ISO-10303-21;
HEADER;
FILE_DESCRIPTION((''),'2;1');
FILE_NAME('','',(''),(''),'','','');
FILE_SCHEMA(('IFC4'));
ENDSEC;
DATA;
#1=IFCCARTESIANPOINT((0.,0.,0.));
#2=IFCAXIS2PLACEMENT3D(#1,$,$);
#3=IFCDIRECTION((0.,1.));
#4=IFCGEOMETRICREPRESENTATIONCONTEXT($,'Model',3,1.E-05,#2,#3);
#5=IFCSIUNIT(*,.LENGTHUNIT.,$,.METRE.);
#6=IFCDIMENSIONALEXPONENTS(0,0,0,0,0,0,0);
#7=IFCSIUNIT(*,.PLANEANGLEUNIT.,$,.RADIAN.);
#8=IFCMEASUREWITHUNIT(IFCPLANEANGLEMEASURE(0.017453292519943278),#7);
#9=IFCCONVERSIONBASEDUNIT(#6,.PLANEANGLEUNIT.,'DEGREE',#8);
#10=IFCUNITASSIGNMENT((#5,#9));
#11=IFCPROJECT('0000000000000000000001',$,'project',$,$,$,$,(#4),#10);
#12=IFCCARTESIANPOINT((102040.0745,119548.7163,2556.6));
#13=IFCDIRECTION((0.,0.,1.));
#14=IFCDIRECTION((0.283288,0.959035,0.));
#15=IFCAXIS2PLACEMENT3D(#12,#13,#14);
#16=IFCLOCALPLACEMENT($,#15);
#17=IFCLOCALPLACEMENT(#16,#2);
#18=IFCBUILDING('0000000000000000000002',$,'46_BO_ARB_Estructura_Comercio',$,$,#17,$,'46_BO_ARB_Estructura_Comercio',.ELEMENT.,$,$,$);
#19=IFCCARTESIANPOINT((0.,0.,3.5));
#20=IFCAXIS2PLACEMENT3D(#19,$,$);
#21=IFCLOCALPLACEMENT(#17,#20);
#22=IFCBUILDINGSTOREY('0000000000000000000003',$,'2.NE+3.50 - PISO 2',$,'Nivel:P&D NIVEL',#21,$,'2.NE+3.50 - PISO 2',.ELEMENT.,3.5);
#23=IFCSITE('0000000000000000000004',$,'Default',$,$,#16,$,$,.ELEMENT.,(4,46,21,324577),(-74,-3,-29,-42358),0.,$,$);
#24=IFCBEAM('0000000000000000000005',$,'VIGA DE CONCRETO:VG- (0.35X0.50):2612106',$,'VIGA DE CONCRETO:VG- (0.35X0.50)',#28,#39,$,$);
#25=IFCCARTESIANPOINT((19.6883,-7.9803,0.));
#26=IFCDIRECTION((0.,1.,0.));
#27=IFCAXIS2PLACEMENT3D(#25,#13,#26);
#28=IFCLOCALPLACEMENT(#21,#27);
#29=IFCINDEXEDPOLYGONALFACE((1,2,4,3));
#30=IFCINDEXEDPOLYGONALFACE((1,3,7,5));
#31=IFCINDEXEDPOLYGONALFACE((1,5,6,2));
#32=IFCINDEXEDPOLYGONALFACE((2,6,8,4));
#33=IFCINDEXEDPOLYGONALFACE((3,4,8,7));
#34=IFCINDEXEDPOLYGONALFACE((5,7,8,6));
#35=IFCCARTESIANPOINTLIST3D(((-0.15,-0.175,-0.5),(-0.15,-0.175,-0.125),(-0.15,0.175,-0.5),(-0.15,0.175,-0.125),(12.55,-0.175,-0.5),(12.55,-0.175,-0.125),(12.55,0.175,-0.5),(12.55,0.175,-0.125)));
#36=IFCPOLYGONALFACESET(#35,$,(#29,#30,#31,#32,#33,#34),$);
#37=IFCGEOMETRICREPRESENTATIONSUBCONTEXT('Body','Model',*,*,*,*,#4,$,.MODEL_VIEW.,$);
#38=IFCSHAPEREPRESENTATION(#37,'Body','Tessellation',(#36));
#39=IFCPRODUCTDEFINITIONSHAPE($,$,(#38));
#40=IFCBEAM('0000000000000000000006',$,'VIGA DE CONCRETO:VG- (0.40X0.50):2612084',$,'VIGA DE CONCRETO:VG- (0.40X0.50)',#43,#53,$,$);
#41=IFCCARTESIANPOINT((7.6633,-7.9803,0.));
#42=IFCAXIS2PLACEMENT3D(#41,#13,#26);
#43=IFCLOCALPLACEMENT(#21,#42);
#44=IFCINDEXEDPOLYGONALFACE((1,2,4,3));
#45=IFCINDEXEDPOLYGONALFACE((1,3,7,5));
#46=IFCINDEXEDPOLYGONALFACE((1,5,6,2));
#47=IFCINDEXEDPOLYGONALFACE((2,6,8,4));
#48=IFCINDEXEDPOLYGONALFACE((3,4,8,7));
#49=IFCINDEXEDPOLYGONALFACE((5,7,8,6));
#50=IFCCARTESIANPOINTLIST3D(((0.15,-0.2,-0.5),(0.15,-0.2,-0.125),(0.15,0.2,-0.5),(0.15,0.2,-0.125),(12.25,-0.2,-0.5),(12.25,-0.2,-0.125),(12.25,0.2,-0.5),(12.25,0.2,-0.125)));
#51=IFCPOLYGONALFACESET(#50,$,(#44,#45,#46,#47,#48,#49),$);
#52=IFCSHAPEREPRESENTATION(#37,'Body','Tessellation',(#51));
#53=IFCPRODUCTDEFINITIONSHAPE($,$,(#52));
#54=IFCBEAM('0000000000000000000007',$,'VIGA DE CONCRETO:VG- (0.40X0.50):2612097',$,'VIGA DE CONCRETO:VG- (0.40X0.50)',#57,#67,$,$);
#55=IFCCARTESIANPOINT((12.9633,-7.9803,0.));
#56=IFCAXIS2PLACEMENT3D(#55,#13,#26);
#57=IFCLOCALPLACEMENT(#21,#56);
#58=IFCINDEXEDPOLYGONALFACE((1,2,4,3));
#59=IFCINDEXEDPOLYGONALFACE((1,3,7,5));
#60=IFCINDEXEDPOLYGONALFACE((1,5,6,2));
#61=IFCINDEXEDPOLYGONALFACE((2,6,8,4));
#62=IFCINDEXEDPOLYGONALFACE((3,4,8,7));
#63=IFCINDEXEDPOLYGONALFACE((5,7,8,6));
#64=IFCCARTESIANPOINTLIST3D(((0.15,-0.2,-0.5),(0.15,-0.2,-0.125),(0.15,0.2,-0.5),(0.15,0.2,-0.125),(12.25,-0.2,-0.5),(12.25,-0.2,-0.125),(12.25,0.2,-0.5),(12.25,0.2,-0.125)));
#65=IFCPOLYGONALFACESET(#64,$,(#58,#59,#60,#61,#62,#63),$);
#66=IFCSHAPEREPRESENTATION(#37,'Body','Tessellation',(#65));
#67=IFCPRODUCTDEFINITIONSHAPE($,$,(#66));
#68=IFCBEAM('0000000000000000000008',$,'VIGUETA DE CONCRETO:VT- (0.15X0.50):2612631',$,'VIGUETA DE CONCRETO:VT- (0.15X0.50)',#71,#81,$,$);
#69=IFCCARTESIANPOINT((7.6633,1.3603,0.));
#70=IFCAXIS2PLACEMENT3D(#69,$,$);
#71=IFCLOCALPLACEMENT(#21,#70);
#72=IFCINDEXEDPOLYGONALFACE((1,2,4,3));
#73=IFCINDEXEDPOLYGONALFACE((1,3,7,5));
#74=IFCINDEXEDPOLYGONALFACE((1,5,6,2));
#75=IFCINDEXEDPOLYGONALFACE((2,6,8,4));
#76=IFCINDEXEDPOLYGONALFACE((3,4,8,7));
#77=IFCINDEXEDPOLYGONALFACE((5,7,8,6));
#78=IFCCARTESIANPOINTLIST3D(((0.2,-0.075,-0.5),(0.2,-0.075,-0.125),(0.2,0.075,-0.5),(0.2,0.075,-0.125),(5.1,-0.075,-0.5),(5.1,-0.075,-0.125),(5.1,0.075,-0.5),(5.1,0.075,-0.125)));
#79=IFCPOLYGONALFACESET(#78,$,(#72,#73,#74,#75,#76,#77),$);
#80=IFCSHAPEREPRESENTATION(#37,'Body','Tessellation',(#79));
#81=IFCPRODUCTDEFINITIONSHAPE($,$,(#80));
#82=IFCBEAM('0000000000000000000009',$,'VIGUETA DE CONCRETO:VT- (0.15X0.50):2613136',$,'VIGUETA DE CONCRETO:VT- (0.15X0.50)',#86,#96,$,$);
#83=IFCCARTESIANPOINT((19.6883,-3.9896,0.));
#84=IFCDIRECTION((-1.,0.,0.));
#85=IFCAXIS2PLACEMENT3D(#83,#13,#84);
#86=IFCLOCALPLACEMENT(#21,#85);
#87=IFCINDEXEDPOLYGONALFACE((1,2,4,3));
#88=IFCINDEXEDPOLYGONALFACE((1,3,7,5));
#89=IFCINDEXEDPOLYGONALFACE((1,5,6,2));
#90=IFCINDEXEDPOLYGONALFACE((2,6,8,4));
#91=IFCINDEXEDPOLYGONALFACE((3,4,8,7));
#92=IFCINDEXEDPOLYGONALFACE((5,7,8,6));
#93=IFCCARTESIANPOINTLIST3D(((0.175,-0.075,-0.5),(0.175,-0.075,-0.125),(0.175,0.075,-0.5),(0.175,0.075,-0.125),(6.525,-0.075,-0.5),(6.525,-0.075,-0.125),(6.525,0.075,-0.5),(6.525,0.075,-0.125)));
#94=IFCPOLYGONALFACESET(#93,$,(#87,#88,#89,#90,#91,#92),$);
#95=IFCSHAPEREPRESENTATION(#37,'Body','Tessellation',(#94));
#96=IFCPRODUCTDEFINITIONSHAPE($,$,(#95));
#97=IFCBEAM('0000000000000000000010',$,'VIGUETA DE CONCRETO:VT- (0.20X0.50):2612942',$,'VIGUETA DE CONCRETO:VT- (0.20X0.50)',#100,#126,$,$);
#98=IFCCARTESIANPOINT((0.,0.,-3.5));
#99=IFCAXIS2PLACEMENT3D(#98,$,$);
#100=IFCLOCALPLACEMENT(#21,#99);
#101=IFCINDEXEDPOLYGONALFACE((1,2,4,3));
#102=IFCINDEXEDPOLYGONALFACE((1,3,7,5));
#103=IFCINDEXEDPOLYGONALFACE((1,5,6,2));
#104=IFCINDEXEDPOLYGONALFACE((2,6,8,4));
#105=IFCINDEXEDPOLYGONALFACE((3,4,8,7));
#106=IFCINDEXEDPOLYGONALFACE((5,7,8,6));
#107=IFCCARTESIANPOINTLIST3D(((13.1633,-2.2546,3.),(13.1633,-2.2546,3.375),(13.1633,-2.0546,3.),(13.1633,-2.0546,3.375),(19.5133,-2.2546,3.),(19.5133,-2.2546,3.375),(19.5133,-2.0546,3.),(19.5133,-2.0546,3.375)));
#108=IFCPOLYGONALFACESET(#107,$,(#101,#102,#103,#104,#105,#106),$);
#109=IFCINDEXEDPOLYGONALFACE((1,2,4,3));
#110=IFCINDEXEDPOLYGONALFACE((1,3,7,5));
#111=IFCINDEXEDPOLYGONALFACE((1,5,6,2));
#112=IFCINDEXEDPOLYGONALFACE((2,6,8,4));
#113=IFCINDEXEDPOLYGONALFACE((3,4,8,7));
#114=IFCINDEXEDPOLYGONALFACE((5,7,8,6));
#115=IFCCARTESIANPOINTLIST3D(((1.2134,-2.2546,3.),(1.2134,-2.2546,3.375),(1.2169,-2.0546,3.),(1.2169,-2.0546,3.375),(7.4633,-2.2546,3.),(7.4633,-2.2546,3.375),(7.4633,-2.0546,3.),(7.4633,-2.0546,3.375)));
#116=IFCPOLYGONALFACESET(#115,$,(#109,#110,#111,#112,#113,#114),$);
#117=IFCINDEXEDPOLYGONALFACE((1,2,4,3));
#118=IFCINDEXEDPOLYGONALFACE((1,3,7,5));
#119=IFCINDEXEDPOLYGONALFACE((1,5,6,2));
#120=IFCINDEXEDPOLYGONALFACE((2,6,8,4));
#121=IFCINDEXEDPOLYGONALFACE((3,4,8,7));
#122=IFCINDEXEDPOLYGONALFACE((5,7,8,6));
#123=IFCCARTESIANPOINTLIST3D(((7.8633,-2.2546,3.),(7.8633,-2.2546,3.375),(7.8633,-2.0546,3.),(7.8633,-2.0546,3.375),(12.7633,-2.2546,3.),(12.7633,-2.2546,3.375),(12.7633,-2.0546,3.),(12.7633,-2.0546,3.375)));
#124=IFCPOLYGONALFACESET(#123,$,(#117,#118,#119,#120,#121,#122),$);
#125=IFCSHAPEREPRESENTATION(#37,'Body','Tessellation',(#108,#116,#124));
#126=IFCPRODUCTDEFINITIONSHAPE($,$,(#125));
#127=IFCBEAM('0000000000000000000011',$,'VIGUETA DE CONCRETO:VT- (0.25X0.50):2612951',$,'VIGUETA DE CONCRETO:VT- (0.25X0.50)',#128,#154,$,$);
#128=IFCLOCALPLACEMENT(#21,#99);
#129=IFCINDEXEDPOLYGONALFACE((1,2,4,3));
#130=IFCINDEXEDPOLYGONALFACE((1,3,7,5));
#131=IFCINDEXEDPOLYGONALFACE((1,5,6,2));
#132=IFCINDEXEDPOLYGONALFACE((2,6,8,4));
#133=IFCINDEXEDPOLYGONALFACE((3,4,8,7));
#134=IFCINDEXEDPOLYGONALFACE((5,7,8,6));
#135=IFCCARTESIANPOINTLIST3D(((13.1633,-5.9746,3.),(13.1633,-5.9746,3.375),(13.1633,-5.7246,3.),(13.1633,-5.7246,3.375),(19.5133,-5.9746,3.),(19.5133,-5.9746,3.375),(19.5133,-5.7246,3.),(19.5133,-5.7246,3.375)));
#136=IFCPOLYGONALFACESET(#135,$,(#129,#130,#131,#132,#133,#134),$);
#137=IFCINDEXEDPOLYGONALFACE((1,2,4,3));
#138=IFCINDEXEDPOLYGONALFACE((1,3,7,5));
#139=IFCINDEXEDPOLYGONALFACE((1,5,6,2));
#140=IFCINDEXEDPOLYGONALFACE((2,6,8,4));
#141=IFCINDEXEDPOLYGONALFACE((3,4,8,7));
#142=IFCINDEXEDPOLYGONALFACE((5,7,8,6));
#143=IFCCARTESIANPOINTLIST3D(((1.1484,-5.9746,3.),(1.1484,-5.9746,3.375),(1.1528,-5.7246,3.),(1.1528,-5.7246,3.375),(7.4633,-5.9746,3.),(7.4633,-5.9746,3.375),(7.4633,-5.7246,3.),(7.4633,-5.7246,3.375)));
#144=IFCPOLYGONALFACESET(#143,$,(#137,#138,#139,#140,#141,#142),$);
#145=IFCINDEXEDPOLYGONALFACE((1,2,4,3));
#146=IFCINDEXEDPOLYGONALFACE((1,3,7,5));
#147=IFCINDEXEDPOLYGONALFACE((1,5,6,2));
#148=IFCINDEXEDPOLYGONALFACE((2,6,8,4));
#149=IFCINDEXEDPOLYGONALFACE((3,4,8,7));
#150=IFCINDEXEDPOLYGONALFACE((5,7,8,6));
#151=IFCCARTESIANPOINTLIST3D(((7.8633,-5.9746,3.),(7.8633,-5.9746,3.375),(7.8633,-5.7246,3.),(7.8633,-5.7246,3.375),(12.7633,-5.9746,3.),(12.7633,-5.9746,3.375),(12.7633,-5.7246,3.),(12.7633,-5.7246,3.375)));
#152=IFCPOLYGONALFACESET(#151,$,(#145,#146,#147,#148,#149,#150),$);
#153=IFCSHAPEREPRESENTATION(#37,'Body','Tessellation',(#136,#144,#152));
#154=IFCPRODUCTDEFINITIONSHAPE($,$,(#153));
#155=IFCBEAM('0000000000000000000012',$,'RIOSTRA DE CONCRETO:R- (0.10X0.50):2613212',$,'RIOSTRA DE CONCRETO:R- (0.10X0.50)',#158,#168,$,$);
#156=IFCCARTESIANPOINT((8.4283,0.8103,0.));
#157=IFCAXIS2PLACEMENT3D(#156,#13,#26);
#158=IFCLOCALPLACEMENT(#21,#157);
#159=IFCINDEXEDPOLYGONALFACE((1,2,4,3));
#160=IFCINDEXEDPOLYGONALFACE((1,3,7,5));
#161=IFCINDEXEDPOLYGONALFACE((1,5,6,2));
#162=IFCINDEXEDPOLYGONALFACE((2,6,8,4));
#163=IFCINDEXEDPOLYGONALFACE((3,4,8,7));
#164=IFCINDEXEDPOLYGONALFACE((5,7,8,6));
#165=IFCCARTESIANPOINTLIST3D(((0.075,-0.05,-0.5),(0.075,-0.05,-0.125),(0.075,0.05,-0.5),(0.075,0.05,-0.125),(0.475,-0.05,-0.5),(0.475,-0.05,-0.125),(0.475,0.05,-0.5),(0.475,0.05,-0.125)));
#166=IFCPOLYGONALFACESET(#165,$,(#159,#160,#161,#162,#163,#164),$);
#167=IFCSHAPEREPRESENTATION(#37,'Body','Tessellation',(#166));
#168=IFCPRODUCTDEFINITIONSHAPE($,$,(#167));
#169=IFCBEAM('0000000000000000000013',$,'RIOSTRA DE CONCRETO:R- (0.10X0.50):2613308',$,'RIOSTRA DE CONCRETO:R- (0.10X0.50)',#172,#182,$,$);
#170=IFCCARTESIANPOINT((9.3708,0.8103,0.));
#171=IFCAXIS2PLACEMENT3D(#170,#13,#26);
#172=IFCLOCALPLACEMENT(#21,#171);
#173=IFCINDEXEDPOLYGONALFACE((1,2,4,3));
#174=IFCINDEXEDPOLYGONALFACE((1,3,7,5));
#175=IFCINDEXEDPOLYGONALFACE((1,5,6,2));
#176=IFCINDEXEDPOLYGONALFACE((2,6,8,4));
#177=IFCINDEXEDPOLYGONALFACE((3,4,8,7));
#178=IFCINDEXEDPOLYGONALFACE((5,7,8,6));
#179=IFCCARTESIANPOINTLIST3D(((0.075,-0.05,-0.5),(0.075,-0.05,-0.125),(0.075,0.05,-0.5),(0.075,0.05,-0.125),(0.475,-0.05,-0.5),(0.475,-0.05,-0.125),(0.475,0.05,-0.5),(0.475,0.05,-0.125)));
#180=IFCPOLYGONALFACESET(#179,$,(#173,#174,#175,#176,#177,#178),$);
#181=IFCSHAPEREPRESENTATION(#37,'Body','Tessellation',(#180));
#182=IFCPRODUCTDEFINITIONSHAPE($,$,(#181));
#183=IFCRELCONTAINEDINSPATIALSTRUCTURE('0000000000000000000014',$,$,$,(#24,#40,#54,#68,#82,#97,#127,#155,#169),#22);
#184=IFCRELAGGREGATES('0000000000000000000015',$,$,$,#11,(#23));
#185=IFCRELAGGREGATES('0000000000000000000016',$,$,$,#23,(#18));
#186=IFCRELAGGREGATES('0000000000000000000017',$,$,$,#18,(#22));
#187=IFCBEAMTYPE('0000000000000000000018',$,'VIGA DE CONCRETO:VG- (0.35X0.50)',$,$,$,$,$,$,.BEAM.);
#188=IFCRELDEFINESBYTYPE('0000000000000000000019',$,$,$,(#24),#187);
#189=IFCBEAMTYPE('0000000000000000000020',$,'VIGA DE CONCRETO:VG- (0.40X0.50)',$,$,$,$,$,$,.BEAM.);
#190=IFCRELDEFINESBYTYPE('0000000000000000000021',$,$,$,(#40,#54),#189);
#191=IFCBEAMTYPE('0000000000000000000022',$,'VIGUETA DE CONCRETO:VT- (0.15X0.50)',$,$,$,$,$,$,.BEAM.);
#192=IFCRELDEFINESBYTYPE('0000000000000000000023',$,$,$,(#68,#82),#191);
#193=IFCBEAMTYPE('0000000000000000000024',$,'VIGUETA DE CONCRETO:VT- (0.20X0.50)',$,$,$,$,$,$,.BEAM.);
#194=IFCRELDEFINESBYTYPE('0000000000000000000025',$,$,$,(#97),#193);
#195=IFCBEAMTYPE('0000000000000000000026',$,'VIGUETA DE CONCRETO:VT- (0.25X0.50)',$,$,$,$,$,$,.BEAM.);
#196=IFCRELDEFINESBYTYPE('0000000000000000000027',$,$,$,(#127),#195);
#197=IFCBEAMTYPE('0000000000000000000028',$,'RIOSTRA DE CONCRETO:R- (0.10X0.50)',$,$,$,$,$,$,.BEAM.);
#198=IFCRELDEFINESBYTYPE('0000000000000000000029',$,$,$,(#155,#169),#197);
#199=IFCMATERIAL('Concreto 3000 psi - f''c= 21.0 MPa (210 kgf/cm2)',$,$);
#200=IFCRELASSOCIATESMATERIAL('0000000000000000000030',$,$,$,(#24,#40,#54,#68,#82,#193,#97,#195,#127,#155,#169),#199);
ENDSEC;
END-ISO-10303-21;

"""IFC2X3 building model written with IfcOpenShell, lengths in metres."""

from ifc_helpers import new_model, entity, si_unit, converted_unit, direction, frame, frame_2d, origin, place, context, subcontext, project, spatial, rectangle, extrude, clip, halfspace, source, transform, mapped, material, type_object, type_shapes, element, save


model = new_model("IFC2X3")

# Units and contexts
model_context = context("Model", 3, precision=1e-05, world=origin(), true_north=direction((0.0, 1.0)))
body_context = subcontext(model_context, "Body", "Model", "MODEL_VIEW")
ifc_project = project(units=[si_unit("LENGTHUNIT", "METRE"), converted_unit("PLANEANGLEUNIT", "DEGREE", entity("IfcPlaneAngleMeasure", 0.017453292519943278), si_unit("PLANEANGLEUNIT", "RADIAN"), dimensions=[0, 0, 0, 0, 0, 0, 0])], contexts=[model_context])

# Site, building, storey
site_placement = place(None, frame((102040.0745, 119548.7163, 2556.6), z_axis=(0.0, 0.0, 1.0), x_axis=(0.283288, 0.959035, 0.0)))
site = spatial("IfcSite", under=ifc_project, at=site_placement, Name="Default", CompositionType="ELEMENT", RefLatitude=(4, 46, 21, 324577), RefLongitude=(-74, -3, -29, -42358), RefElevation=0.0)
building_placement = place(site_placement, origin())
building = spatial("IfcBuilding", under=site, at=building_placement, Name="46_BO_ARB_Estructura_Comercio", LongName="46_BO_ARB_Estructura_Comercio", CompositionType="ELEMENT")
storey_placement = place(building_placement, frame((0.0, 0.0, 3.5)))
storey = spatial("IfcBuildingStorey", under=building, at=storey_placement, Name="2.NE+3.50 - PISO 2", ObjectType="Nivel:P&D NIVEL", LongName="2.NE+3.50 - PISO 2", CompositionType="ELEMENT", Elevation=3.5)

# Beams
ifc_material = material(Name="Concreto 3000 psi - f'c= 21.0 MPa (210 kgf/cm2)")
beam_type_1 = type_object("IfcBeamType", Name="VIGA DE CONCRETO:VG- (0.35X0.50)", PredefinedType="BEAM")
beam_1_placement = place(storey_placement, frame((19.6883, -7.9803, 0.0), z_axis=(0.0, 0.0, 1.0), x_axis=(0.0, 1.0, 0.0)))
element("IfcBeam", 1, at=beam_1_placement, inside=storey, type_object=beam_type_1, material=ifc_material, Name="VIGA DE CONCRETO:VG- (0.35X0.50):2612106", ObjectType="VIGA DE CONCRETO:VG- (0.35X0.50)", context=body_context, shape_type="SweptSolid", body=[
    extrude(rectangle(XDim=0.375, YDim=0.35, at=frame_2d((0.0, 0.0), x_axis=(1.0, 0.0))), frame((-0.15, 0.0, -0.3125), z_axis=(1.0, 0.0, 0.0), x_axis=(0.0, 0.0, -1.0)), (0.0, 0.0, 1.0), 12.7),
])
beam_type_2 = type_object("IfcBeamType", Name="VIGA DE CONCRETO:VG- (0.40X0.50)", PredefinedType="BEAM")
beam_2_placement = place(storey_placement, frame((7.6633, -7.9803, 0.0), z_axis=(0.0, 0.0, 1.0), x_axis=(0.0, 1.0, 0.0)))
element("IfcBeam", 2, at=beam_2_placement, inside=storey, type_object=beam_type_2, material=ifc_material, Name="VIGA DE CONCRETO:VG- (0.40X0.50):2612084", ObjectType="VIGA DE CONCRETO:VG- (0.40X0.50)", context=body_context, shape_type="SweptSolid", body=[
    extrude(rectangle(XDim=0.375, YDim=0.4, at=frame_2d((0.0, 0.0), x_axis=(1.0, 0.0))), frame((0.15, 0.0, -0.3125), z_axis=(1.0, 0.0, 0.0), x_axis=(0.0, 0.0, -1.0)), (0.0, 0.0, 1.0), 12.1),
])
beam_3_placement = place(storey_placement, frame((12.9633, -7.9803, 0.0), z_axis=(0.0, 0.0, 1.0), x_axis=(0.0, 1.0, 0.0)))
element("IfcBeam", 3, at=beam_3_placement, inside=storey, type_object=beam_type_2, material=ifc_material, Name="VIGA DE CONCRETO:VG- (0.40X0.50):2612097", ObjectType="VIGA DE CONCRETO:VG- (0.40X0.50)", context=body_context, shape_type="SweptSolid", body=[
    extrude(rectangle(XDim=0.375, YDim=0.4, at=frame_2d((0.0, 0.0), x_axis=(1.0, 0.0))), frame((0.15, 0.0, -0.3125), z_axis=(1.0, 0.0, 0.0), x_axis=(0.0, 0.0, -1.0)), (0.0, 0.0, 1.0), 12.1),
])
beam_type_3 = type_object("IfcBeamType", Name="VIGUETA DE CONCRETO:VT- (0.15X0.50)", PredefinedType="BEAM")
beam_4_placement = place(storey_placement, frame((7.6633, 1.3603, 0.0)))
element("IfcBeam", 4, at=beam_4_placement, inside=storey, type_object=beam_type_3, material=ifc_material, Name="VIGUETA DE CONCRETO:VT- (0.15X0.50):2612631", ObjectType="VIGUETA DE CONCRETO:VT- (0.15X0.50)", context=body_context, shape_type="SweptSolid", body=[
    extrude(rectangle(XDim=0.375, YDim=0.15, at=frame_2d((0.0, 0.0), x_axis=(1.0, 0.0))), frame((0.2, 0.0, -0.3125), z_axis=(1.0, 0.0, 0.0), x_axis=(0.0, 0.0, -1.0)), (0.0, 0.0, 1.0), 4.9),
])
beam_5_placement = place(storey_placement, frame((19.6883, -3.9896, 0.0), z_axis=(0.0, 0.0, 1.0), x_axis=(-1.0, 0.0, 0.0)))
element("IfcBeam", 5, at=beam_5_placement, inside=storey, type_object=beam_type_3, material=ifc_material, Name="VIGUETA DE CONCRETO:VT- (0.15X0.50):2613136", ObjectType="VIGUETA DE CONCRETO:VT- (0.15X0.50)", context=body_context, shape_type="SweptSolid", body=[
    extrude(rectangle(XDim=0.375, YDim=0.15, at=frame_2d((0.0, 0.0), x_axis=(1.0, 0.0))), frame((0.175, 0.0, -0.3125), z_axis=(1.0, 0.0, 0.0), x_axis=(0.0, 0.0, -1.0)), (0.0, 0.0, 1.0), 6.35),
])
beam_type_4 = type_object("IfcBeamType", Name="VIGUETA DE CONCRETO:VT- (0.20X0.50)", PredefinedType="BEAM", material=ifc_material)
shared_shape_1 = source(origin(), body_context, "Body", "SweptSolid", [
    extrude(rectangle(XDim=0.375, YDim=0.2, at=frame_2d((0.0, 0.0), x_axis=(1.0, 0.0))), frame((13.1633, -2.1546, 3.1875), z_axis=(1.0, 0.0, 0.0), x_axis=(0.0, 0.0, -1.0)), (0.0, 0.0, 1.0), 6.35),
    clip(extrude(rectangle(XDim=0.375, YDim=0.2, at=frame_2d((0.0, 0.0), x_axis=(1.0, 0.0))), frame((1.2134, -2.1546, 3.1875), z_axis=(1.0, 0.0, 0.0), x_axis=(0.0, 0.0, -1.0)), (0.0, 0.0, 1.0), 6.2499), halfspace(frame((1.2357, -0.9774, 3.5), z_axis=(-0.999847, 0.017477, 0.0), x_axis=(-0.017477, -0.999847, 0.0)), False)),
    extrude(rectangle(XDim=0.375, YDim=0.2, at=frame_2d((0.0, 0.0), x_axis=(1.0, 0.0))), frame((7.8633, -2.1546, 3.1875), z_axis=(1.0, 0.0, 0.0), x_axis=(0.0, 0.0, -1.0)), (0.0, 0.0, 1.0), 4.9),
])
type_shapes(beam_type_4, [shared_shape_1])
beam_6_placement = place(storey_placement, frame((0.0, 0.0, -3.5)))
element("IfcBeam", 6, at=beam_6_placement, inside=storey, type_object=beam_type_4, material=ifc_material, Name="VIGUETA DE CONCRETO:VT- (0.20X0.50):2612942", ObjectType="VIGUETA DE CONCRETO:VT- (0.20X0.50)", context=body_context, shape_type="MappedRepresentation", body=[
    mapped(shared_shape_1, transform((0.0, 0.0, 0.0), scale=1.0)),
])
beam_type_5 = type_object("IfcBeamType", Name="VIGUETA DE CONCRETO:VT- (0.25X0.50)", PredefinedType="BEAM", material=ifc_material)
shared_shape_2 = source(origin(), body_context, "Body", "SweptSolid", [
    extrude(rectangle(XDim=0.375, YDim=0.25, at=frame_2d((0.0, 0.0), x_axis=(1.0, 0.0))), frame((13.1633, -5.8496, 3.1875), z_axis=(1.0, 0.0, 0.0), x_axis=(0.0, 0.0, -1.0)), (0.0, 0.0, 1.0), 6.35),
    clip(extrude(rectangle(XDim=0.375, YDim=0.25, at=frame_2d((0.0, 0.0), x_axis=(1.0, 0.0))), frame((1.1484, -5.8496, 3.1875), z_axis=(1.0, 0.0, 0.0), x_axis=(0.0, 0.0, -1.0)), (0.0, 0.0, 1.0), 6.3149), halfspace(frame((1.2357, -0.9774, 3.5), z_axis=(-0.999847, 0.017477, 0.0), x_axis=(-0.017477, -0.999847, 0.0)), False)),
    extrude(rectangle(XDim=0.375, YDim=0.25, at=frame_2d((0.0, 0.0), x_axis=(1.0, 0.0))), frame((7.8633, -5.8496, 3.1875), z_axis=(1.0, 0.0, 0.0), x_axis=(0.0, 0.0, -1.0)), (0.0, 0.0, 1.0), 4.9),
])
type_shapes(beam_type_5, [shared_shape_2])
beam_7_placement = place(storey_placement, frame((0.0, 0.0, -3.5)))
element("IfcBeam", 7, at=beam_7_placement, inside=storey, type_object=beam_type_5, material=ifc_material, Name="VIGUETA DE CONCRETO:VT- (0.25X0.50):2612951", ObjectType="VIGUETA DE CONCRETO:VT- (0.25X0.50)", context=body_context, shape_type="MappedRepresentation", body=[
    mapped(shared_shape_2, transform((0.0, 0.0, 0.0), scale=1.0)),
])
beam_type_6 = type_object("IfcBeamType", Name="RIOSTRA DE CONCRETO:R- (0.10X0.50)", PredefinedType="BEAM")
beam_8_placement = place(storey_placement, frame((8.4283, 0.8103, 0.0), z_axis=(0.0, 0.0, 1.0), x_axis=(0.0, 1.0, 0.0)))
element("IfcBeam", 8, at=beam_8_placement, inside=storey, type_object=beam_type_6, material=ifc_material, Name="RIOSTRA DE CONCRETO:R- (0.10X0.50):2613212", ObjectType="RIOSTRA DE CONCRETO:R- (0.10X0.50)", context=body_context, shape_type="SweptSolid", body=[
    extrude(rectangle(XDim=0.375, YDim=0.1, at=frame_2d((0.0, 0.0), x_axis=(1.0, 0.0))), frame((0.075, 0.0, -0.3125), z_axis=(1.0, 0.0, 0.0), x_axis=(0.0, 0.0, -1.0)), (0.0, 0.0, 1.0), 0.4),
])
beam_9_placement = place(storey_placement, frame((9.3708, 0.8103, 0.0), z_axis=(0.0, 0.0, 1.0), x_axis=(0.0, 1.0, 0.0)))
element("IfcBeam", 9, at=beam_9_placement, inside=storey, type_object=beam_type_6, material=ifc_material, Name="RIOSTRA DE CONCRETO:R- (0.10X0.50):2613308", ObjectType="RIOSTRA DE CONCRETO:R- (0.10X0.50)", context=body_context, shape_type="SweptSolid", body=[
    extrude(rectangle(XDim=0.375, YDim=0.1, at=frame_2d((0.0, 0.0), x_axis=(1.0, 0.0))), frame((0.075, 0.0, -0.3125), z_axis=(1.0, 0.0, 0.0), x_axis=(0.0, 0.0, -1.0)), (0.0, 0.0, 1.0), 0.4),
])

save(model, "model.ifc")
